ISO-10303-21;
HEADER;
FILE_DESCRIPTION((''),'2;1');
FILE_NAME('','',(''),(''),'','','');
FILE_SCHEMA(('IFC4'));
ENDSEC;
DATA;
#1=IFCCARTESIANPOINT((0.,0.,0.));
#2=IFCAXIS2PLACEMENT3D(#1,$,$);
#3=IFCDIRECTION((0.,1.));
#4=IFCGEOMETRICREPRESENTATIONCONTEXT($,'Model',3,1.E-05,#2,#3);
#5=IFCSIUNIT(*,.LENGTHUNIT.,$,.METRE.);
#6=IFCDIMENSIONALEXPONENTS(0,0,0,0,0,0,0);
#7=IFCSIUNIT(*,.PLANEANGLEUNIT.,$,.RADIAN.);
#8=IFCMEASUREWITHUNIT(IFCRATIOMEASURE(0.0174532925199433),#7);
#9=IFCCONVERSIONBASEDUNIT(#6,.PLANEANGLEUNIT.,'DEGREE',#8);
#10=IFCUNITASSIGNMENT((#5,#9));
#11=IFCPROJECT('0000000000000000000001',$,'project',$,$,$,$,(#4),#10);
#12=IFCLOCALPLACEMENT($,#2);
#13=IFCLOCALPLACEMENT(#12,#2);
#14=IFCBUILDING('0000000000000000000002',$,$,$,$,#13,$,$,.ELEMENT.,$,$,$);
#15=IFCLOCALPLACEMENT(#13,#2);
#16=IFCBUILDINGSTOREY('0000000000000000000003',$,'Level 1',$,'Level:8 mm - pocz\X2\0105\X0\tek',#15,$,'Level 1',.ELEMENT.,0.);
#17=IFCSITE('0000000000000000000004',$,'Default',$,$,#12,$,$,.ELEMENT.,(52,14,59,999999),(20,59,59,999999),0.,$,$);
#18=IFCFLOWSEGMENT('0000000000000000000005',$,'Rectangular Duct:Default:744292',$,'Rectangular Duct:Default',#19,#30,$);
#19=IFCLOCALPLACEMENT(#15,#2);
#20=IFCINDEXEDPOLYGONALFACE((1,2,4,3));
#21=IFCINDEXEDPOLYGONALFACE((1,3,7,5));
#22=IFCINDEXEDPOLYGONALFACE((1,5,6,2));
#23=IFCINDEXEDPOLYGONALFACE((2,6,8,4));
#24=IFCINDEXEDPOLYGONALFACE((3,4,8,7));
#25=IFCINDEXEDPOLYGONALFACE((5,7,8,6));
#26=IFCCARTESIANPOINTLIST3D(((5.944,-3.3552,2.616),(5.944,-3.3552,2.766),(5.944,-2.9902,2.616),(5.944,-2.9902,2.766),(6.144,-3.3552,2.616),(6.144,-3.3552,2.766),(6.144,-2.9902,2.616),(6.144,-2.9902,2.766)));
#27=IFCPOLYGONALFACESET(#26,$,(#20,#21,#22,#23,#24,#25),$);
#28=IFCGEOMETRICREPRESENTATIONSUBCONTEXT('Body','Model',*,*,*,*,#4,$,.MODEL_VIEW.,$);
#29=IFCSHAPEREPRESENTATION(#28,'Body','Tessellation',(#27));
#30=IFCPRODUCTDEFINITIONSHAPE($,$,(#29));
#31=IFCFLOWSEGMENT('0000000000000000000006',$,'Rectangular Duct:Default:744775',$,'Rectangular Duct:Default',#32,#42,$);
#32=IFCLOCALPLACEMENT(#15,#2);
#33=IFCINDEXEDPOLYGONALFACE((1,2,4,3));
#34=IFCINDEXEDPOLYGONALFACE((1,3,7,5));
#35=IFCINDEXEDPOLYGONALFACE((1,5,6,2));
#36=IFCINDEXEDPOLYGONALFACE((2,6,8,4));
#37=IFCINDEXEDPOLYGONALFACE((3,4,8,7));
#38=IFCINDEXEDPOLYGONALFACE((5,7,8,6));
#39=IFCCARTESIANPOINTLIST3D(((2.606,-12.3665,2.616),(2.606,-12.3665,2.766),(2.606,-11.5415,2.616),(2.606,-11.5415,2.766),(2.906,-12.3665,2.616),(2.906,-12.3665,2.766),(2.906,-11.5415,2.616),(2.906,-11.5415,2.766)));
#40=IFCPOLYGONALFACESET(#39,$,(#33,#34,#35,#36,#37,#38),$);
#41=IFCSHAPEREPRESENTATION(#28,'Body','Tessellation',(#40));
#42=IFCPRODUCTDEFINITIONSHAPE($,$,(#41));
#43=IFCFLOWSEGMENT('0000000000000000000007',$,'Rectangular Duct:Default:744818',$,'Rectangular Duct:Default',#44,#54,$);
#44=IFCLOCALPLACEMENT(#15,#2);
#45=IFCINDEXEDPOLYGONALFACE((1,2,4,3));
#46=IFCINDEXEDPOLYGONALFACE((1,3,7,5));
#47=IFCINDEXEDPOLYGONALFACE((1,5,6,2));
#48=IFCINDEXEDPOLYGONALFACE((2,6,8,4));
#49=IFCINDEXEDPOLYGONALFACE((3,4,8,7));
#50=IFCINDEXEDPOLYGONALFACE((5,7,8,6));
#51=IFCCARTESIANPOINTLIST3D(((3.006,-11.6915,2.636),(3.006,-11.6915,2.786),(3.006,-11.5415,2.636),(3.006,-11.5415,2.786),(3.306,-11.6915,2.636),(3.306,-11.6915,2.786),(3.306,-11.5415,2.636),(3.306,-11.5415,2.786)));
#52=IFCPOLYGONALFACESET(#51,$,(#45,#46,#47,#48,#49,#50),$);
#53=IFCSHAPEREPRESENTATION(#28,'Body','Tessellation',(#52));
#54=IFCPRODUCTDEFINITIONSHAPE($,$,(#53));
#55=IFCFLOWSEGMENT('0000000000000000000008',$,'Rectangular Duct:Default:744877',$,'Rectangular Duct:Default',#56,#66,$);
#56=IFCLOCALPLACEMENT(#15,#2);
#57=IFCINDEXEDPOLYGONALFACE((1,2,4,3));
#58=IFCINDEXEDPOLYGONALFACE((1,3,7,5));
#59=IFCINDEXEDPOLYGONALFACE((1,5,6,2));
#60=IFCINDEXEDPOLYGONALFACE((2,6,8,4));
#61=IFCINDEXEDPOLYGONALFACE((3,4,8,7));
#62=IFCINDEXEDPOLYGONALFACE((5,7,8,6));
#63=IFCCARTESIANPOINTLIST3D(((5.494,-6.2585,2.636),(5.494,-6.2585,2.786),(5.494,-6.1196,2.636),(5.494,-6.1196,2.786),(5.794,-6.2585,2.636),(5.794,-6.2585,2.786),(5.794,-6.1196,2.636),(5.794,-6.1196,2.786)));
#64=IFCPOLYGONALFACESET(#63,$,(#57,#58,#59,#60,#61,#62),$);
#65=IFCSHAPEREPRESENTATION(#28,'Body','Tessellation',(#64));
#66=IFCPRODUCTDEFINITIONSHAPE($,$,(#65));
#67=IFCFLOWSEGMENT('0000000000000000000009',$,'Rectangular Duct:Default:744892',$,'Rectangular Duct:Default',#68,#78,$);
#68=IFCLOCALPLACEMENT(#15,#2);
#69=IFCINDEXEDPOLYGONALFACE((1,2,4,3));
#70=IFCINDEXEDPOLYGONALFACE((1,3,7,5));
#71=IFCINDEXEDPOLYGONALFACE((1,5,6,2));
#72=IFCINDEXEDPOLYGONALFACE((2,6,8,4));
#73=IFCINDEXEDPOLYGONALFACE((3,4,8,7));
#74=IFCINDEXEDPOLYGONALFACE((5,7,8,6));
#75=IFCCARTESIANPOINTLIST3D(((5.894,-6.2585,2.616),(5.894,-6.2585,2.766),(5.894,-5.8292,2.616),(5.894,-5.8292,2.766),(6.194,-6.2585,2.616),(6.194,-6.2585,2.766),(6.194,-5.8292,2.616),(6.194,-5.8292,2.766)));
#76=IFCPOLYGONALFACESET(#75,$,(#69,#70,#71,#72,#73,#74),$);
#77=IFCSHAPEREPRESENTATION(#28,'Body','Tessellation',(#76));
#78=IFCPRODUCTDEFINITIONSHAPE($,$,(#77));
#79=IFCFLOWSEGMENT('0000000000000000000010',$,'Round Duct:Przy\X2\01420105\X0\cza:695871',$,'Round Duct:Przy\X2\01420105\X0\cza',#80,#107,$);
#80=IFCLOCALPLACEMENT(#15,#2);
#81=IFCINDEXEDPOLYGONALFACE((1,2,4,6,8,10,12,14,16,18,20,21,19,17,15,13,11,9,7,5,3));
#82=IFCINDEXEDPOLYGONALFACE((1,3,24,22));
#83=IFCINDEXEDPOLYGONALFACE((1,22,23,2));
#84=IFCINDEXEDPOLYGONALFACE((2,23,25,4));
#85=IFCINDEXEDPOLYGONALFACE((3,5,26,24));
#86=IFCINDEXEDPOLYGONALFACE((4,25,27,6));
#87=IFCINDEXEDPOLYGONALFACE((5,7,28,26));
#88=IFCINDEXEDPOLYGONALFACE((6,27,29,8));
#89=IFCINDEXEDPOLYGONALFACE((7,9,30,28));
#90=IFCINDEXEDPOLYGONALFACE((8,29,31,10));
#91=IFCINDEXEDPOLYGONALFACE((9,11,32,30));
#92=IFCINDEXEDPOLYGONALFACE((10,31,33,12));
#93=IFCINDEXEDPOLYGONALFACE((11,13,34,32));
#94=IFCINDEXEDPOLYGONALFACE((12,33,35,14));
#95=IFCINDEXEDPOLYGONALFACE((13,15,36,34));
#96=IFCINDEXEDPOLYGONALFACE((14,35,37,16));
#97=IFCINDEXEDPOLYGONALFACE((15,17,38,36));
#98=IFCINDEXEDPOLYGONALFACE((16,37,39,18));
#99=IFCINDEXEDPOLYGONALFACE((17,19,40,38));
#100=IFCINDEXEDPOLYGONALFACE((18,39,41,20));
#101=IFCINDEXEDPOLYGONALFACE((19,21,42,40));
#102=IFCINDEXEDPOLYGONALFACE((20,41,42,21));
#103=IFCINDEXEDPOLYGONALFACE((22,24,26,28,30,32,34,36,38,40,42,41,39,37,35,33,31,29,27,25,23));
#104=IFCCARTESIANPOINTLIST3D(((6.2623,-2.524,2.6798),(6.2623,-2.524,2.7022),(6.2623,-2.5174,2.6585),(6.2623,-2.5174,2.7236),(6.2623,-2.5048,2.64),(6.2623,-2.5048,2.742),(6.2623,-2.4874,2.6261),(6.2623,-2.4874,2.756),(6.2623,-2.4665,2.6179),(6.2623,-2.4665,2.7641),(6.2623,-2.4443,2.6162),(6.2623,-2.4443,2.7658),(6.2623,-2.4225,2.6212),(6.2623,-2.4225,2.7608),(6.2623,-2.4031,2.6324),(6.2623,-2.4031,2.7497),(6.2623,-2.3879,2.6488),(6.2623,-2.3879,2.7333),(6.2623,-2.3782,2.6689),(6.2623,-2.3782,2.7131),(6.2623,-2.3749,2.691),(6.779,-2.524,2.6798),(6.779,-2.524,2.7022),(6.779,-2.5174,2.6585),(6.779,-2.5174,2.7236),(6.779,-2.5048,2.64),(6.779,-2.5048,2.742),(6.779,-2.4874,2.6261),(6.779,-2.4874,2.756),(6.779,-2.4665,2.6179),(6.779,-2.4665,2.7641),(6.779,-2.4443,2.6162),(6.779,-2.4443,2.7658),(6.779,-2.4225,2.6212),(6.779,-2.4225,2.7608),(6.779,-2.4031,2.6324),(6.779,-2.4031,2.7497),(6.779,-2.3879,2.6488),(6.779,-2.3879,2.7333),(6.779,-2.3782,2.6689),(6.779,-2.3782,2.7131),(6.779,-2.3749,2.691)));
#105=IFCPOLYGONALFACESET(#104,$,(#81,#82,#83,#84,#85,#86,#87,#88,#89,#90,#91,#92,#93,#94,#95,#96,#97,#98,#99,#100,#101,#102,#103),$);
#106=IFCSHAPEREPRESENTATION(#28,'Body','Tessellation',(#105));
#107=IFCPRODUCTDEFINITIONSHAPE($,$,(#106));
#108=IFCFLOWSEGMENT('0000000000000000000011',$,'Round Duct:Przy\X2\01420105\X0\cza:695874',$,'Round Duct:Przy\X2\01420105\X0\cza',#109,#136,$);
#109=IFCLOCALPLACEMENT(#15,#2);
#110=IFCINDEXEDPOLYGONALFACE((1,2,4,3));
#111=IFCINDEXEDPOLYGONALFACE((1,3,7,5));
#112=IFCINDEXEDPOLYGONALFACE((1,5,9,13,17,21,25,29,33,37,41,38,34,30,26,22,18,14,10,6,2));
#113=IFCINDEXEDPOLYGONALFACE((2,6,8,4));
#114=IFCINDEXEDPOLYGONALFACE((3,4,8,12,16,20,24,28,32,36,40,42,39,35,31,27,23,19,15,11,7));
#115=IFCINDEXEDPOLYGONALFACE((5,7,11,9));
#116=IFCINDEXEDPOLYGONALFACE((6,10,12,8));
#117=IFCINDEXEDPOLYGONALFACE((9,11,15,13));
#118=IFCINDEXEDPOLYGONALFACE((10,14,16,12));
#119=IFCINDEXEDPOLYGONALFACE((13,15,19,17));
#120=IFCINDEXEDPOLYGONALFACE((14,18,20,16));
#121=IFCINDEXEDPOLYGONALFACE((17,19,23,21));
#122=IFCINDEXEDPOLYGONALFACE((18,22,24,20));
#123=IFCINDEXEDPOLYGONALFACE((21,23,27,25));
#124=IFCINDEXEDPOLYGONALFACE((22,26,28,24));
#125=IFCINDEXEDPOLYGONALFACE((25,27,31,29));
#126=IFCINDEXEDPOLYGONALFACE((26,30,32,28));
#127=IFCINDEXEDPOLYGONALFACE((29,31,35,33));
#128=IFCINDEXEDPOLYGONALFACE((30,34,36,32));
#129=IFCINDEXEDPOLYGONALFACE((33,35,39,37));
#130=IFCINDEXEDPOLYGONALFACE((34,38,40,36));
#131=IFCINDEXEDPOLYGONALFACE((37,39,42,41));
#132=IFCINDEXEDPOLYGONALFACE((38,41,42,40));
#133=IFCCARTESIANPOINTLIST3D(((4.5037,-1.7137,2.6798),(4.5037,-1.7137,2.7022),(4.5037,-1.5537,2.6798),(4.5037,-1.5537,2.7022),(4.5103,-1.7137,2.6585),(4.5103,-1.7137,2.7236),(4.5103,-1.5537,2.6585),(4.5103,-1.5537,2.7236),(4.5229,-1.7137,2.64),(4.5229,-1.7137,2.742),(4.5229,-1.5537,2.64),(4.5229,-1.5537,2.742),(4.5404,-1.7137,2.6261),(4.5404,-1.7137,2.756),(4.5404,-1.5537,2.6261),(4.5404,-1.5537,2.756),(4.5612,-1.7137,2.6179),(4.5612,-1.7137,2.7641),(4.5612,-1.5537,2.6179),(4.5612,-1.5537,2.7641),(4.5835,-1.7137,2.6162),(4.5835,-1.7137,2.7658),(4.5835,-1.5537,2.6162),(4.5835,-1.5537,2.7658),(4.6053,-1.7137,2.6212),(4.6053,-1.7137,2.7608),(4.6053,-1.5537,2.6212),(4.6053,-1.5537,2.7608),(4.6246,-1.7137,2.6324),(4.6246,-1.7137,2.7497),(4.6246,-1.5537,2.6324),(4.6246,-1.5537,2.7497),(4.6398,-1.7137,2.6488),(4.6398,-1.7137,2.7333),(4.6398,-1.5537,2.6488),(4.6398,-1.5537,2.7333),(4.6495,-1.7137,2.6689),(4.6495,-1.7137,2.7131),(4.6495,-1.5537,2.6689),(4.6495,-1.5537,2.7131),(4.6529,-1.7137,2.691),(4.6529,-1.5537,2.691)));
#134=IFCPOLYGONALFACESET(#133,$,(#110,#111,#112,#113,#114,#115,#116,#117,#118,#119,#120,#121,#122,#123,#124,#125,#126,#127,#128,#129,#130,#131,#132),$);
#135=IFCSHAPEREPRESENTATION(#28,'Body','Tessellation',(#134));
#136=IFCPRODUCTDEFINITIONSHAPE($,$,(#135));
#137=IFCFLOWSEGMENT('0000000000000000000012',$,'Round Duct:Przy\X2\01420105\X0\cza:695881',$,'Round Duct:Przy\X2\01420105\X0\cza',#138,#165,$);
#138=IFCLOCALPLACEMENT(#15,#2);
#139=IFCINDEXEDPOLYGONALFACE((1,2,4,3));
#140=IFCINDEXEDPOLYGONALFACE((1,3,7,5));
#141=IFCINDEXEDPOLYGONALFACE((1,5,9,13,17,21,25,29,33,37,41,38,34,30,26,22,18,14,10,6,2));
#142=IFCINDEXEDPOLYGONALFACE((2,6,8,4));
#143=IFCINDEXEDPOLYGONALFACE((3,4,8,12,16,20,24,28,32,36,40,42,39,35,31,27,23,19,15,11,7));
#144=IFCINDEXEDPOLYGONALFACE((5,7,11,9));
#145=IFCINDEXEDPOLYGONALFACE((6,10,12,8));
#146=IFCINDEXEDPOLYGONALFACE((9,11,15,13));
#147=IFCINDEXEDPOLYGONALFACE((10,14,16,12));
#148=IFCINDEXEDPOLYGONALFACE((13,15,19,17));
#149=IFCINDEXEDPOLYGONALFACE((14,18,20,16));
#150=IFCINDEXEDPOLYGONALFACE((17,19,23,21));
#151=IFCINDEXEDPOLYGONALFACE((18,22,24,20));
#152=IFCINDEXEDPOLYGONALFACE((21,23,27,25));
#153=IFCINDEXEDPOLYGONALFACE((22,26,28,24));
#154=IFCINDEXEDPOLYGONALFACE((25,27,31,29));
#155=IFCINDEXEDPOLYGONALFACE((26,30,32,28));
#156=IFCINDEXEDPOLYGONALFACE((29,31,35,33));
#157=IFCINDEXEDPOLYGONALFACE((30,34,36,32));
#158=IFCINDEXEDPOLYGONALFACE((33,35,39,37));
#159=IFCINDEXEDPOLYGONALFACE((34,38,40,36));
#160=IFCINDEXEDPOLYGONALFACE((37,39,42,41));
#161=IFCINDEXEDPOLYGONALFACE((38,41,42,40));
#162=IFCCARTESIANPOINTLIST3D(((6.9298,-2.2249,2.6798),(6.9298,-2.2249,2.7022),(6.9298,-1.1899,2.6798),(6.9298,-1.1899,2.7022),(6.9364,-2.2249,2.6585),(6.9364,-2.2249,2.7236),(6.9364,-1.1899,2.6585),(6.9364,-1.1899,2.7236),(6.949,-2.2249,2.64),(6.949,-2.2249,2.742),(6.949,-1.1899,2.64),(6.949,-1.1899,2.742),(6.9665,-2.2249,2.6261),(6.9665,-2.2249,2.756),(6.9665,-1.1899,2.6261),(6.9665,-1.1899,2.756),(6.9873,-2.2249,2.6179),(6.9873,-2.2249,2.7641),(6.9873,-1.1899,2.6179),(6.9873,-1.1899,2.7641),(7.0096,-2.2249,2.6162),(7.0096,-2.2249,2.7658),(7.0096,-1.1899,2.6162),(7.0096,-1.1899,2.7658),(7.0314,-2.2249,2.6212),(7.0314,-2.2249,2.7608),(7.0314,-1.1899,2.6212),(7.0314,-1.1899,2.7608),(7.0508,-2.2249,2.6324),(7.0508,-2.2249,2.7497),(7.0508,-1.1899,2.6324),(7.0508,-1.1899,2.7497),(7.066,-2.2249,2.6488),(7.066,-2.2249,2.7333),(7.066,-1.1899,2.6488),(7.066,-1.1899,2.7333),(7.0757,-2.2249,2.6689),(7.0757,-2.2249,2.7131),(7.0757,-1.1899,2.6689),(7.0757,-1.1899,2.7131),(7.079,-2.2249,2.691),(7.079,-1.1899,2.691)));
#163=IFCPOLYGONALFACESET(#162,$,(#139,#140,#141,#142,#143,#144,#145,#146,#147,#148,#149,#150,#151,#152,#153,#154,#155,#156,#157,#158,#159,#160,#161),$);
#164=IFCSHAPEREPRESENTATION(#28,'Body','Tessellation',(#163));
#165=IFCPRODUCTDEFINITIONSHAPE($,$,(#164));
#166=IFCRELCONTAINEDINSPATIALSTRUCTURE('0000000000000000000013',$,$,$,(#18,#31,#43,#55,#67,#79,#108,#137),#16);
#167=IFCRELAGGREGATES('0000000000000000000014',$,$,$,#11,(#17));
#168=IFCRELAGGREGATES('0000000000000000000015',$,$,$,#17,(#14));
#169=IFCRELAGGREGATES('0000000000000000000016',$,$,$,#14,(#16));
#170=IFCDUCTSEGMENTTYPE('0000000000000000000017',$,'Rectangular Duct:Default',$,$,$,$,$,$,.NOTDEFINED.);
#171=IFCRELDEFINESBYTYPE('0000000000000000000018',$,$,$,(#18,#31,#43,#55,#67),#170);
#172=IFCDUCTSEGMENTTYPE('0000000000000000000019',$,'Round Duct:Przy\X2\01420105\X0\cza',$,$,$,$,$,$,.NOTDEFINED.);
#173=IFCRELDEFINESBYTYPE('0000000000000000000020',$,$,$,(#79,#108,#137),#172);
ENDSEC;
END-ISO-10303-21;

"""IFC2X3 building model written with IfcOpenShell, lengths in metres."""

from ifc_helpers import new_model, entity, si_unit, converted_unit, direction, frame, frame_2d, origin, origin_2d_with_axis, place, context, subcontext, project, spatial, rectangle, circle, extrude, type_object, element, save


model = new_model("IFC2X3")

# Units and contexts
model_context = context("Model", 3, precision=1e-05, world=origin(), true_north=direction((0.0, 1.0)))
body_context = subcontext(model_context, "Body", "Model", "MODEL_VIEW")
ifc_project = project(units=[si_unit("LENGTHUNIT", "METRE"), converted_unit("PLANEANGLEUNIT", "DEGREE", entity("IfcRatioMeasure", 0.0174532925199433), si_unit("PLANEANGLEUNIT", "RADIAN"), dimensions=[0, 0, 0, 0, 0, 0, 0])], contexts=[model_context])

# Site, building, storey
site_placement = place(None, origin())
site = spatial("IfcSite", under=ifc_project, at=site_placement, Name="Default", CompositionType="ELEMENT", RefLatitude=(52, 14, 59, 999999), RefLongitude=(20, 59, 59, 999999), RefElevation=0.0)
building_placement = place(site_placement, origin())
building = spatial("IfcBuilding", under=site, at=building_placement, CompositionType="ELEMENT")
storey_placement = place(building_placement, origin())
storey = spatial("IfcBuildingStorey", under=building, at=storey_placement, Name="Level 1", ObjectType="Level:8 mm - początek", LongName="Level 1", CompositionType="ELEMENT", Elevation=0.0)

# Flow segments
duct_segment_type_1 = type_object("IfcDuctSegmentType", Name="Rectangular Duct:Default", PredefinedType="NOTDEFINED")
flow_segment_1_placement = place(storey_placement, origin())
element("IfcFlowSegment", 1, at=flow_segment_1_placement, inside=storey, type_object=duct_segment_type_1, Name="Rectangular Duct:Default:744292", ObjectType="Rectangular Duct:Default", context=body_context, shape_type="SweptSolid", body=[
    extrude(rectangle(XDim=0.365, YDim=0.2, at=frame_2d((0.0, 0.0), x_axis=(1.0, 0.0))), frame((6.044, -3.1727, 2.616), z_axis=(0.0, 0.0, 1.0), x_axis=(0.0, 1.0, 0.0)), (0.0, 0.0, 1.0), 0.15),
])
flow_segment_2_placement = place(storey_placement, origin())
element("IfcFlowSegment", 2, at=flow_segment_2_placement, inside=storey, type_object=duct_segment_type_1, Name="Rectangular Duct:Default:744775", ObjectType="Rectangular Duct:Default", context=body_context, shape_type="SweptSolid", body=[
    extrude(rectangle(XDim=0.825, YDim=0.3, at=frame_2d((0.0, 0.0), x_axis=(1.0, 0.0))), frame((2.756, -11.954, 2.616), z_axis=(0.0, 0.0, 1.0), x_axis=(0.0, -1.0, 0.0)), (0.0, 0.0, 1.0), 0.15),
])
flow_segment_3_placement = place(storey_placement, origin())
element("IfcFlowSegment", 3, at=flow_segment_3_placement, inside=storey, type_object=duct_segment_type_1, Name="Rectangular Duct:Default:744818", ObjectType="Rectangular Duct:Default", context=body_context, shape_type="SweptSolid", body=[
    extrude(rectangle(XDim=0.15, YDim=0.3, at=origin_2d_with_axis()), frame((3.156, -11.6165, 2.636), z_axis=(0.0, 0.0, 1.0), x_axis=(0.0, -1.0, 0.0)), (0.0, 0.0, 1.0), 0.15),
])
flow_segment_4_placement = place(storey_placement, origin())
element("IfcFlowSegment", 4, at=flow_segment_4_placement, inside=storey, type_object=duct_segment_type_1, Name="Rectangular Duct:Default:744877", ObjectType="Rectangular Duct:Default", context=body_context, shape_type="SweptSolid", body=[
    extrude(rectangle(XDim=0.1389, YDim=0.3, at=origin_2d_with_axis()), frame((5.644, -6.189, 2.636), z_axis=(0.0, 0.0, 1.0), x_axis=(0.0, 1.0, 0.0)), (0.0, 0.0, 1.0), 0.15),
])
flow_segment_5_placement = place(storey_placement, origin())
element("IfcFlowSegment", 5, at=flow_segment_5_placement, inside=storey, type_object=duct_segment_type_1, Name="Rectangular Duct:Default:744892", ObjectType="Rectangular Duct:Default", context=body_context, shape_type="SweptSolid", body=[
    extrude(rectangle(XDim=0.4293, YDim=0.3, at=frame_2d((0.0, 0.0), x_axis=(1.0, 0.0))), frame((6.044, -6.0439, 2.616), z_axis=(0.0, 0.0, 1.0), x_axis=(0.0, 1.0, 0.0)), (0.0, 0.0, 1.0), 0.15),
])
duct_segment_type_2 = type_object("IfcDuctSegmentType", Name="Round Duct:Przyłącza", PredefinedType="NOTDEFINED")
flow_segment_6_placement = place(storey_placement, origin())
element("IfcFlowSegment", 6, at=flow_segment_6_placement, inside=storey, type_object=duct_segment_type_2, Name="Round Duct:Przyłącza:695871", ObjectType="Round Duct:Przyłącza", context=body_context, shape_type="SweptSolid", body=[
    extrude(circle(Radius=0.075, at=frame_2d((0.0, 0.0), x_axis=(1.0, 0.0))), frame((6.2623, -2.4499, 2.691), z_axis=(1.0, 0.0, 0.0), x_axis=(0.0, 1.0, 0.0)), (0.0, 0.0, 1.0), 0.5167),
])
flow_segment_7_placement = place(storey_placement, origin())
element("IfcFlowSegment", 7, at=flow_segment_7_placement, inside=storey, type_object=duct_segment_type_2, Name="Round Duct:Przyłącza:695874", ObjectType="Round Duct:Przyłącza", context=body_context, shape_type="SweptSolid", body=[
    extrude(circle(Radius=0.075, at=frame_2d((0.0, 0.0), x_axis=(1.0, 0.0))), frame((4.5779, -1.7137, 2.691), z_axis=(0.0, 1.0, 0.0), x_axis=(1.0, 0.0, 0.0)), (0.0, 0.0, 1.0), 0.16),
])
flow_segment_8_placement = place(storey_placement, origin())
element("IfcFlowSegment", 8, at=flow_segment_8_placement, inside=storey, type_object=duct_segment_type_2, Name="Round Duct:Przyłącza:695881", ObjectType="Round Duct:Przyłącza", context=body_context, shape_type="SweptSolid", body=[
    extrude(circle(Radius=0.075, at=origin_2d_with_axis()), frame((7.004, -2.2249, 2.691), z_axis=(0.0, 1.0, 0.0), x_axis=(1.0, 0.0, 0.0)), (0.0, 0.0, 1.0), 1.035),
])

save(model, "model.ifc")
